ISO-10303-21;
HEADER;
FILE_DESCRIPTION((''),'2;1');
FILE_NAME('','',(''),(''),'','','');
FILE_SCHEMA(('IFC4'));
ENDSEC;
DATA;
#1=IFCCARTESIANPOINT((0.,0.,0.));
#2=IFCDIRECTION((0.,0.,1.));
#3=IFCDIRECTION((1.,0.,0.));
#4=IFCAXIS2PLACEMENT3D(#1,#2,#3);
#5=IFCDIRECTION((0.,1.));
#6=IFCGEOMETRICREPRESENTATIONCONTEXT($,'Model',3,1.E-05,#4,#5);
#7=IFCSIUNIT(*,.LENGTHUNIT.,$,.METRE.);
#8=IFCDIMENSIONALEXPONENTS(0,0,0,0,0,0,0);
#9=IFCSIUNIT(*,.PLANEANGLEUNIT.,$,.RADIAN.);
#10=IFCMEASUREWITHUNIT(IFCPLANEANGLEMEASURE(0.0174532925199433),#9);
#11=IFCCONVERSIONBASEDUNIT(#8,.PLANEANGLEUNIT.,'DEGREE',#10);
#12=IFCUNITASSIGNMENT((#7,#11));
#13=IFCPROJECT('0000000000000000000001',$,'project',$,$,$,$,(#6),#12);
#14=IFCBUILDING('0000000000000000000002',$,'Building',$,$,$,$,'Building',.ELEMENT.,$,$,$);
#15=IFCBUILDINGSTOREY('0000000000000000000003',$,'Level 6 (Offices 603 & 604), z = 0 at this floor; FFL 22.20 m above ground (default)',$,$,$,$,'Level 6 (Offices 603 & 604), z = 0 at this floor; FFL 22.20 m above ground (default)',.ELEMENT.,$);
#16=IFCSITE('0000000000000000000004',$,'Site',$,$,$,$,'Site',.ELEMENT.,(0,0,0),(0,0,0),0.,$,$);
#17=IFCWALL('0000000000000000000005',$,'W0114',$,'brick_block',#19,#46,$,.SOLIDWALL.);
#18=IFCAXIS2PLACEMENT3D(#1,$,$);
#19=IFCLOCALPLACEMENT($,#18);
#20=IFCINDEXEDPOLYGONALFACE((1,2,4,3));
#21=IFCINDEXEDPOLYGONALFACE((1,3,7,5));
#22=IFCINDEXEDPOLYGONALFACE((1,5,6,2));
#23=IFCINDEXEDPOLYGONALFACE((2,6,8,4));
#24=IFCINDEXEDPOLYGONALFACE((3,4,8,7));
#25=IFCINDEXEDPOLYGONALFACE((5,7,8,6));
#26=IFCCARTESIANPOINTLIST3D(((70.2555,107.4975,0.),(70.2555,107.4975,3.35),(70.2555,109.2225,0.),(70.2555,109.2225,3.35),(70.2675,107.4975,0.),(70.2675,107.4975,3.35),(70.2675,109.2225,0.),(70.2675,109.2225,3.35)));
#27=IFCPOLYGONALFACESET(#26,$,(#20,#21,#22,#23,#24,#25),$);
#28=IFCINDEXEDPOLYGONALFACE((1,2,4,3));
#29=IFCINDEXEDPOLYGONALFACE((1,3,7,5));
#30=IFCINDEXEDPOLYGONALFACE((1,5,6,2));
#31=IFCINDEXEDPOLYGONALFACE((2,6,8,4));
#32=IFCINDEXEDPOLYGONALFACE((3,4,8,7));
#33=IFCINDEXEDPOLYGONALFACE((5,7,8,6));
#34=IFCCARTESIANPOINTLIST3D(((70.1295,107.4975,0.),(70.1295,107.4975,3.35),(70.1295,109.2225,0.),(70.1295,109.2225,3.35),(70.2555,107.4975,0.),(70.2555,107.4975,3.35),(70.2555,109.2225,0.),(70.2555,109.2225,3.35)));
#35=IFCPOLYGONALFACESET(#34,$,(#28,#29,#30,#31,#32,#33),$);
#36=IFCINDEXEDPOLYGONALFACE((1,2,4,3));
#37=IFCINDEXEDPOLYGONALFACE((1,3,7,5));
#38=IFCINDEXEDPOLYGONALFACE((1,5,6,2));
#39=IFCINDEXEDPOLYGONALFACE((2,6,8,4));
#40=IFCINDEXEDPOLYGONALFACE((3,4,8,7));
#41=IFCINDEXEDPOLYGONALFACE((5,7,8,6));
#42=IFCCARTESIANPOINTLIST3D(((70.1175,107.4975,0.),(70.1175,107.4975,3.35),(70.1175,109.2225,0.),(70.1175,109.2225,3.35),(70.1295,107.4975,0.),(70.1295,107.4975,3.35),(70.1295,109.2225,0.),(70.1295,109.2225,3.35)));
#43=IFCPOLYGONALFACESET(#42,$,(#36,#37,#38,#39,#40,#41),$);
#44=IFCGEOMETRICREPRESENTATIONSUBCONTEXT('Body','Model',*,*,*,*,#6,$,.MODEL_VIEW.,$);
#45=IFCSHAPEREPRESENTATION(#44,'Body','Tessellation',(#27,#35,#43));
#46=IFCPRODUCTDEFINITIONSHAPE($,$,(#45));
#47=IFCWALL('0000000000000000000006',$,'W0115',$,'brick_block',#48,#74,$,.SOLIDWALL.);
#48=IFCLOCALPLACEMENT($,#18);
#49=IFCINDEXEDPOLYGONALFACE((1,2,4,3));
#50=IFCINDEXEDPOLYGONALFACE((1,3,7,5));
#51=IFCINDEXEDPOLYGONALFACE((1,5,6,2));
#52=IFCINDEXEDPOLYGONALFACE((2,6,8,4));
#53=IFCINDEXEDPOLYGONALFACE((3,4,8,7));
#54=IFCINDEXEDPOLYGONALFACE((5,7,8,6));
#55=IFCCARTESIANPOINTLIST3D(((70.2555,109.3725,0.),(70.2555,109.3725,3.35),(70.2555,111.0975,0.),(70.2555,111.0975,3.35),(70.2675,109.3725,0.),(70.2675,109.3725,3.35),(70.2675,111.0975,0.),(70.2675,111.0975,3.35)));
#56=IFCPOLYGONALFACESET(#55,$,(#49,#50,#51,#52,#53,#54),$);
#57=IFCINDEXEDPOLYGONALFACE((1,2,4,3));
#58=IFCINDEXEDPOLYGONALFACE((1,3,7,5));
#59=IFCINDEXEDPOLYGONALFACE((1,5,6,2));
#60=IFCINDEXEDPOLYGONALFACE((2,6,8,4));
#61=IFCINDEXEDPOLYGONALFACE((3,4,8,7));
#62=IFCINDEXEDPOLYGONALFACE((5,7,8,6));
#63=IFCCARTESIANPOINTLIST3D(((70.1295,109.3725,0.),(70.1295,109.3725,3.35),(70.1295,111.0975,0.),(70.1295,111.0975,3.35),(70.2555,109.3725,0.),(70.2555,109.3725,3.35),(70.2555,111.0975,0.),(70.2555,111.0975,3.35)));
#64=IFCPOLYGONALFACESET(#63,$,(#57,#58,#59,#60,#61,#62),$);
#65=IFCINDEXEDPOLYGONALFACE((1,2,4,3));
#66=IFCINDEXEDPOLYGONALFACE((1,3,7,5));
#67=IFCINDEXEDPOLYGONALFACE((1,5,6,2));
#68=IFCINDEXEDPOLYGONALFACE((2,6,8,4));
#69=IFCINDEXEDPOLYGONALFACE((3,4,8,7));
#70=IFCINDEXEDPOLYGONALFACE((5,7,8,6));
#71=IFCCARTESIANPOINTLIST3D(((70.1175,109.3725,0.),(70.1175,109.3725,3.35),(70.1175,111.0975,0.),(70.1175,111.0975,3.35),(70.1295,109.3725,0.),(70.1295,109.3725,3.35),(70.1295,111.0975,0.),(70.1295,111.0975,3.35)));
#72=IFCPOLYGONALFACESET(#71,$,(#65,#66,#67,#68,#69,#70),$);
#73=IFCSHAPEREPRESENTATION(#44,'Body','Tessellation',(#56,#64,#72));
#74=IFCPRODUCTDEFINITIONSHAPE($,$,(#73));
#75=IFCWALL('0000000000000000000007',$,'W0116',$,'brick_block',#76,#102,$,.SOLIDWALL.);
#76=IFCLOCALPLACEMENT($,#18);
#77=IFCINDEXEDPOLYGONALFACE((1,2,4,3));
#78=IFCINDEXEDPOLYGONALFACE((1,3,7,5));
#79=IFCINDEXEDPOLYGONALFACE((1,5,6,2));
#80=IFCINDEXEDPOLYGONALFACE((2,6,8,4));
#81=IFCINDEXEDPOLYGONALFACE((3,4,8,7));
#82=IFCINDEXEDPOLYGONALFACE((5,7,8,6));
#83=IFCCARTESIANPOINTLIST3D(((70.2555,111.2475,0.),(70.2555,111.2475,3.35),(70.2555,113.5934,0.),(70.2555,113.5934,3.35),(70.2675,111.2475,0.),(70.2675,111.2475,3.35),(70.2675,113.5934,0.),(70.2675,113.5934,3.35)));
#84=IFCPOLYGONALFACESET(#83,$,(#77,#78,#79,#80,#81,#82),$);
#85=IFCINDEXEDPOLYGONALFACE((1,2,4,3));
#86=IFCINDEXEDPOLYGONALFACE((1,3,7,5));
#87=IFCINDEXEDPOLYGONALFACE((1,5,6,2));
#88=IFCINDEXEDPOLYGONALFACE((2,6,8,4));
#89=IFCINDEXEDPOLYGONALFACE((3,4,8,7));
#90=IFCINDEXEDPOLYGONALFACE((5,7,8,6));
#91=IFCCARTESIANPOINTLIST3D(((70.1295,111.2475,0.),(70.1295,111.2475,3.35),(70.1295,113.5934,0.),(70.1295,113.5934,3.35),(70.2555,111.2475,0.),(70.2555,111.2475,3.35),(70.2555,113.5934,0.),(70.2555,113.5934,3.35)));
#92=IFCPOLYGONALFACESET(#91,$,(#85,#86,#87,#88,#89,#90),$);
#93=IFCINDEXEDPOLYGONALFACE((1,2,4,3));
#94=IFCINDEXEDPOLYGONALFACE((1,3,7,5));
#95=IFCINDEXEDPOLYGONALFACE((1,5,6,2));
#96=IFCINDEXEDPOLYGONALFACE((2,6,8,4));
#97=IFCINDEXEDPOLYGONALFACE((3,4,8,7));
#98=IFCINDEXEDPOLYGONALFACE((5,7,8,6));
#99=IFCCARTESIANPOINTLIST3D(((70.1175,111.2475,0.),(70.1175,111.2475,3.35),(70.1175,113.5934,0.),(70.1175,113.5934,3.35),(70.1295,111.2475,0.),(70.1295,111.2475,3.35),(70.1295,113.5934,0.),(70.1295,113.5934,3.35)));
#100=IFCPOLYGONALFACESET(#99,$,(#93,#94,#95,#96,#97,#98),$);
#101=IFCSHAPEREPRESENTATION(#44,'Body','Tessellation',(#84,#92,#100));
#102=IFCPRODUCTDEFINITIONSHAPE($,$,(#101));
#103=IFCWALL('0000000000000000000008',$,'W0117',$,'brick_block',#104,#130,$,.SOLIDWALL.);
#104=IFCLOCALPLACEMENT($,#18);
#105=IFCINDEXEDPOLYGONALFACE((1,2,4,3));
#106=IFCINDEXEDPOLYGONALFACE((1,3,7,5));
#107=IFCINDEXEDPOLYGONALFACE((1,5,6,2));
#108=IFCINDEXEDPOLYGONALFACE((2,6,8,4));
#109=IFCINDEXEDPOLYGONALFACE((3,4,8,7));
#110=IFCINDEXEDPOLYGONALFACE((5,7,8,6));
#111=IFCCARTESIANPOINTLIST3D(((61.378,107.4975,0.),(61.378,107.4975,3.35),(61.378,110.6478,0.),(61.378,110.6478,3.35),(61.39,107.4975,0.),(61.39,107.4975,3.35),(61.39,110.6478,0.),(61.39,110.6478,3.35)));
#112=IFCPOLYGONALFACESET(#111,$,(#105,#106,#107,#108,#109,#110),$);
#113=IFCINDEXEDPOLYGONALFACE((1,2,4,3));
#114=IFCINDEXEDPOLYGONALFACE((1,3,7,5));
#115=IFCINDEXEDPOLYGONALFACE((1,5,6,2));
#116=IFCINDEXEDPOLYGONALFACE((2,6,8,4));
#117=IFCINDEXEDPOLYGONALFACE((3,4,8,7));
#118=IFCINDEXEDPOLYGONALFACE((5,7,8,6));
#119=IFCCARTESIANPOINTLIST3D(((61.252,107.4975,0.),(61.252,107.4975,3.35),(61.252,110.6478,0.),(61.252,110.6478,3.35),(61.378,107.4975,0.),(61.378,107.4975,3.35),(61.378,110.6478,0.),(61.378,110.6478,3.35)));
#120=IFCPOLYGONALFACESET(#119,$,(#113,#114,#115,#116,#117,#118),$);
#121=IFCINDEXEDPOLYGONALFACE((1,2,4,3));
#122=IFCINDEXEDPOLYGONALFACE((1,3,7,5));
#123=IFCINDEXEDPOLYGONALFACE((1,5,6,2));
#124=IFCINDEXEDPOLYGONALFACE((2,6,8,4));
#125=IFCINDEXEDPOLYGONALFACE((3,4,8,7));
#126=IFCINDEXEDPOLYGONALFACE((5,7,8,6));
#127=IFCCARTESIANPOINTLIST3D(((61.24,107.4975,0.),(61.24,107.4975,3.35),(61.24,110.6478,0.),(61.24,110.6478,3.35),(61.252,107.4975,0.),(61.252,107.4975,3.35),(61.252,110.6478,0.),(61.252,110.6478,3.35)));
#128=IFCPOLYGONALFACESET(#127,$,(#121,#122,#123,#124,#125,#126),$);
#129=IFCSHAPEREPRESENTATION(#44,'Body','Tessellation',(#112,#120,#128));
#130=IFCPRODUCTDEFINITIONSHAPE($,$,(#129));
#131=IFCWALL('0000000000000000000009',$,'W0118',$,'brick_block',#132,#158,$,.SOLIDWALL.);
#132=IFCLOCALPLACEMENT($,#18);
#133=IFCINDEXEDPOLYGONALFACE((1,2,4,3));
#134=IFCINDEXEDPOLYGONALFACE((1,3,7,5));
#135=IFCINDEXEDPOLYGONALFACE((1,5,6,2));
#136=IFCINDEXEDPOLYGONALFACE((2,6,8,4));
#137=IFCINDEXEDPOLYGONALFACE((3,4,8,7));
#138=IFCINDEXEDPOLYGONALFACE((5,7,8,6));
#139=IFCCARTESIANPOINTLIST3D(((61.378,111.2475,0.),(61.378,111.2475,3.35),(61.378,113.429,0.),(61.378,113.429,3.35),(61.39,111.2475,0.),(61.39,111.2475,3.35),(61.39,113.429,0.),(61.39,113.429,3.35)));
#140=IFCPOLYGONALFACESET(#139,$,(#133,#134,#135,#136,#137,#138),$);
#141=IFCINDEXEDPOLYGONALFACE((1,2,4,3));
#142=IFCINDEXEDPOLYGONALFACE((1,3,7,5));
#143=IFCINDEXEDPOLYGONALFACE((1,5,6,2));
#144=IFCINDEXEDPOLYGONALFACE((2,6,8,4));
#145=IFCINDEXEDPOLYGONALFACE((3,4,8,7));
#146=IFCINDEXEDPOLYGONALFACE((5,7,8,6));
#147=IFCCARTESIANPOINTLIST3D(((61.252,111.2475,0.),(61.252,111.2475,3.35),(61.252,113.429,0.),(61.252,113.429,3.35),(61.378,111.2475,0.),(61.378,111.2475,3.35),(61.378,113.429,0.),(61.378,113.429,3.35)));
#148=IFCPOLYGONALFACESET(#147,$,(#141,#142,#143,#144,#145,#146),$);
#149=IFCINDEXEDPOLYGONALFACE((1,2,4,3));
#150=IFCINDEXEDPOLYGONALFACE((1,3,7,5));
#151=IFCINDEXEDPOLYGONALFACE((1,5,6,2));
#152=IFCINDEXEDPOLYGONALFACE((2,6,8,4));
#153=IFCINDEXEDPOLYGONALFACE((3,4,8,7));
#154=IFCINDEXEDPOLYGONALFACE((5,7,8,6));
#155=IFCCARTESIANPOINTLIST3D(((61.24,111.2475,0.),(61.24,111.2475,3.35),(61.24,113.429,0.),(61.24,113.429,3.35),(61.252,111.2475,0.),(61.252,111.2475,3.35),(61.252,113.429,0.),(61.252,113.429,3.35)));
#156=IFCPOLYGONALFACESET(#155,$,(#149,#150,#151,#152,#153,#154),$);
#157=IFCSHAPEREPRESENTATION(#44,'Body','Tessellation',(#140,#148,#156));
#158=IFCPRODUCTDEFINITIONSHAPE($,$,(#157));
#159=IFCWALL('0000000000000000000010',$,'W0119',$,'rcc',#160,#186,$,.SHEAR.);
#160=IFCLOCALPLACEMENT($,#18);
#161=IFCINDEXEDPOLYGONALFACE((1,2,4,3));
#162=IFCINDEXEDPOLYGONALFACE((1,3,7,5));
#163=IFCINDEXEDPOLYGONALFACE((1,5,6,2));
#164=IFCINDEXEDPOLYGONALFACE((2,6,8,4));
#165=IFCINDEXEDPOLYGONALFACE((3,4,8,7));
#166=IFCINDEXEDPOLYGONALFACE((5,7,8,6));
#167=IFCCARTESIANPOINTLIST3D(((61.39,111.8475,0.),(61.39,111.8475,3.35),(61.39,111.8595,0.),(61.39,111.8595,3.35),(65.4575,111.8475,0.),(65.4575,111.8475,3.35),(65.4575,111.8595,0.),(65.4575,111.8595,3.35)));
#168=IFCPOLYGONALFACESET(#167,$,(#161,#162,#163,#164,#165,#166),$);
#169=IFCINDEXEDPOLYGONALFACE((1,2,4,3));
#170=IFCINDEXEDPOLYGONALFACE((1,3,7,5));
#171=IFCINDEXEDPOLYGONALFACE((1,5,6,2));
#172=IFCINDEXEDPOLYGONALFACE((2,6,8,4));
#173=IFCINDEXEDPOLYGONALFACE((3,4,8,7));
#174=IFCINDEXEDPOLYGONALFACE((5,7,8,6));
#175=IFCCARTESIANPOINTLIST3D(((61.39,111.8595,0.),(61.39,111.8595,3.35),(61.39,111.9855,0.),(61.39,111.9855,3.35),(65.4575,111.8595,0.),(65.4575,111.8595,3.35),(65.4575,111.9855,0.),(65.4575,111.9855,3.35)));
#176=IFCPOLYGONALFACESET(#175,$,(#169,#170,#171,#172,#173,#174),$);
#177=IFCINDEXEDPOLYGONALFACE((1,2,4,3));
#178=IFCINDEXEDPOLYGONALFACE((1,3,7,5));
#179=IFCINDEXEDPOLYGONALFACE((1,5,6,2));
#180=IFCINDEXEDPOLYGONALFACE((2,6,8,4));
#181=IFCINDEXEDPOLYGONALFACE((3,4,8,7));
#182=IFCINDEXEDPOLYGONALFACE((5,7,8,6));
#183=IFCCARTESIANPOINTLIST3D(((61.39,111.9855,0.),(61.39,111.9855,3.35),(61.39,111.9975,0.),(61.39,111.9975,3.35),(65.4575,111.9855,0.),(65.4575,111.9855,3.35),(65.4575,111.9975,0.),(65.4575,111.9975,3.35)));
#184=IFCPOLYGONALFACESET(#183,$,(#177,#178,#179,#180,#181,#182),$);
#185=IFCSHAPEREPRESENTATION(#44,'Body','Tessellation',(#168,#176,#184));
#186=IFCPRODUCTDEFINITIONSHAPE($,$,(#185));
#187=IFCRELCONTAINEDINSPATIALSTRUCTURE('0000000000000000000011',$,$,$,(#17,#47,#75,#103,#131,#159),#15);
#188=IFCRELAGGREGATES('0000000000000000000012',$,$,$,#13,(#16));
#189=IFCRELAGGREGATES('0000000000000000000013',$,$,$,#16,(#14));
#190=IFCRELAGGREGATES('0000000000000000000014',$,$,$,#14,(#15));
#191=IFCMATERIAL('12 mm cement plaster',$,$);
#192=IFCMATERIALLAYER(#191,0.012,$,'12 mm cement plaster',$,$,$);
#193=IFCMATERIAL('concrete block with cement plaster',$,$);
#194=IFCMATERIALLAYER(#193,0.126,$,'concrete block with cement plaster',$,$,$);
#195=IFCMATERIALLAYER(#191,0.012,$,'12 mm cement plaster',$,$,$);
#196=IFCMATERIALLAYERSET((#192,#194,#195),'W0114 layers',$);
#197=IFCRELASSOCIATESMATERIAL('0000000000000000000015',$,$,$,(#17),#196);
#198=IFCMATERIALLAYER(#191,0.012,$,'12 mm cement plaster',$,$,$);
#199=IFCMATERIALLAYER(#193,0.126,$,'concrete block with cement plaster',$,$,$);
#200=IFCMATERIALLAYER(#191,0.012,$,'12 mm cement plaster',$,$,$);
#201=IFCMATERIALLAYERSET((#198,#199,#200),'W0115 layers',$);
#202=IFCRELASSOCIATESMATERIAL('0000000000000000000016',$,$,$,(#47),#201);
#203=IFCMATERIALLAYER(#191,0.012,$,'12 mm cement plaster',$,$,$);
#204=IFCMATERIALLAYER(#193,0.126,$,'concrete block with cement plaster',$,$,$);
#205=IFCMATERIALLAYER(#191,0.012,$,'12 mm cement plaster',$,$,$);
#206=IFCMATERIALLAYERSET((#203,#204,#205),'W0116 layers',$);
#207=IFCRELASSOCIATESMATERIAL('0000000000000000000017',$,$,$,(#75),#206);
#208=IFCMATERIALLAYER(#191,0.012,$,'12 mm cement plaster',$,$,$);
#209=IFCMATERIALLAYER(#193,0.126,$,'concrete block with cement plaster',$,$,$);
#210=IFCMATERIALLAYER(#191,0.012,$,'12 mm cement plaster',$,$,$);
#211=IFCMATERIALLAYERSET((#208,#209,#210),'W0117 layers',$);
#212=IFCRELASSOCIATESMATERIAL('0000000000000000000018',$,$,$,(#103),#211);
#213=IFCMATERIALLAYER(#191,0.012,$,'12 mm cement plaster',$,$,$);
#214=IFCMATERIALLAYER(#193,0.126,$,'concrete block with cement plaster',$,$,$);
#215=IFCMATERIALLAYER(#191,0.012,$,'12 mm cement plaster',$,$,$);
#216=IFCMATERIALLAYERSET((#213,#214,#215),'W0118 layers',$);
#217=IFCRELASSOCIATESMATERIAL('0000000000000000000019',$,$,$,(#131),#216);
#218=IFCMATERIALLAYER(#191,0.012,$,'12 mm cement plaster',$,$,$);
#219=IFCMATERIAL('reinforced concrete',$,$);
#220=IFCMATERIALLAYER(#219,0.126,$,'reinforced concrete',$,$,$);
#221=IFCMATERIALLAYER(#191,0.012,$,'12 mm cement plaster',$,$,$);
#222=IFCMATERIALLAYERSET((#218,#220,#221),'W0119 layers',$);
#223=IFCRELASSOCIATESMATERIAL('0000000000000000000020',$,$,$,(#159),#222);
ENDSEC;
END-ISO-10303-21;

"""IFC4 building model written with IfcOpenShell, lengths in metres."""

from ifc_helpers import new_model, entity, si_unit, converted_unit, direction, frame, frame_2d, origin_with_axes, place, context, subcontext, project, spatial, rectangle, extrude, material, layer, layer_set, layer_usage, element, save


model = new_model("IFC4")

# Units and contexts
model_context = context("Model", 3, precision=1e-05, world=origin_with_axes(), true_north=direction((0.0, 1.0)))
body_context = subcontext(model_context, "Body", "Model", "MODEL_VIEW")
ifc_project = project(units=[si_unit("LENGTHUNIT", "METRE"), converted_unit("PLANEANGLEUNIT", "DEGREE", entity("IfcPlaneAngleMeasure", 0.0174532925199433), si_unit("PLANEANGLEUNIT", "RADIAN"), dimensions=[0, 0, 0, 0, 0, 0, 0])], contexts=[model_context])

# Site, building, storey
site = spatial("IfcSite", under=ifc_project, Name="Site", LongName="Site", CompositionType="ELEMENT", RefLatitude=(0, 0, 0), RefLongitude=(0, 0, 0), RefElevation=0.0)
building = spatial("IfcBuilding", under=site, Name="Building", LongName="Building", CompositionType="ELEMENT")
storey = spatial("IfcBuildingStorey", under=building, Name="Level 6 (Offices 603 & 604), z = 0 at this floor; FFL 22.20 m above ground (default)", LongName="Level 6 (Offices 603 & 604), z = 0 at this floor; FFL 22.20 m above ground (default)", CompositionType="ELEMENT")

# Walls
ifc_material_1 = material(Name="12 mm cement plaster")
ifc_layer_1 = layer(ifc_material_1, 0.012, Name="12 mm cement plaster")
ifc_material_2 = material(Name="concrete block with cement plaster")
ifc_layer_2 = layer(ifc_material_2, 0.126, Name="concrete block with cement plaster")
ifc_layer_3 = layer(ifc_material_1, 0.012, Name="12 mm cement plaster")
ifc_layer_set_1 = layer_set([ifc_layer_1, ifc_layer_2, ifc_layer_3], Name="W0114 layers")
ifc_layer_usage_1 = layer_usage(ifc_layer_set_1, "AXIS2", "POSITIVE", -0.075)
placement = place(None, origin_with_axes())
element("IfcWall", 1, at=placement, inside=storey, material=ifc_layer_usage_1, Name="W0114", ObjectType="brick_block", PredefinedType="SOLIDWALL", context=body_context, shape_type="SweptSolid", body=[
    extrude(rectangle(XDim=1.725, YDim=0.012, at=frame_2d((0.0, 0.0), x_axis=(0.0, 1.0))), frame((70.2615, 108.36, 0.0), z_axis=(0.0, 0.0, 1.0), x_axis=(1.0, 0.0, 0.0)), (0.0, 0.0, 1.0), 3.35),
    extrude(rectangle(XDim=1.725, YDim=0.126, at=frame_2d((-0.069, 0.0), x_axis=(0.0, 1.0))), frame((70.2615, 108.36, 0.0), z_axis=(0.0, 0.0, 1.0), x_axis=(1.0, 0.0, 0.0)), (0.0, 0.0, 1.0), 3.35),
    extrude(rectangle(XDim=1.725, YDim=0.012, at=frame_2d((-0.138, 0.0), x_axis=(0.0, 1.0))), frame((70.2615, 108.36, 0.0), z_axis=(0.0, 0.0, 1.0), x_axis=(1.0, 0.0, 0.0)), (0.0, 0.0, 1.0), 3.35),
])
ifc_layer_4 = layer(ifc_material_1, 0.012, Name="12 mm cement plaster")
ifc_layer_5 = layer(ifc_material_2, 0.126, Name="concrete block with cement plaster")
ifc_layer_6 = layer(ifc_material_1, 0.012, Name="12 mm cement plaster")
ifc_layer_set_2 = layer_set([ifc_layer_4, ifc_layer_5, ifc_layer_6], Name="W0115 layers")
ifc_layer_usage_2 = layer_usage(ifc_layer_set_2, "AXIS2", "POSITIVE", -0.075)
element("IfcWall", 2, at=placement, inside=storey, material=ifc_layer_usage_2, Name="W0115", ObjectType="brick_block", PredefinedType="SOLIDWALL", context=body_context, shape_type="SweptSolid", body=[
    extrude(rectangle(XDim=1.725, YDim=0.012, at=frame_2d((0.0, 0.0), x_axis=(0.0, 1.0))), frame((70.2615, 110.235, 0.0), z_axis=(0.0, 0.0, 1.0), x_axis=(1.0, 0.0, 0.0)), (0.0, 0.0, 1.0), 3.35),
    extrude(rectangle(XDim=1.725, YDim=0.126, at=frame_2d((-0.069, 0.0), x_axis=(0.0, 1.0))), frame((70.2615, 110.235, 0.0), z_axis=(0.0, 0.0, 1.0), x_axis=(1.0, 0.0, 0.0)), (0.0, 0.0, 1.0), 3.35),
    extrude(rectangle(XDim=1.725, YDim=0.012, at=frame_2d((-0.138, 0.0), x_axis=(0.0, 1.0))), frame((70.2615, 110.235, 0.0), z_axis=(0.0, 0.0, 1.0), x_axis=(1.0, 0.0, 0.0)), (0.0, 0.0, 1.0), 3.35),
])
ifc_layer_7 = layer(ifc_material_1, 0.012, Name="12 mm cement plaster")
ifc_layer_8 = layer(ifc_material_2, 0.126, Name="concrete block with cement plaster")
ifc_layer_9 = layer(ifc_material_1, 0.012, Name="12 mm cement plaster")
ifc_layer_set_3 = layer_set([ifc_layer_7, ifc_layer_8, ifc_layer_9], Name="W0116 layers")
ifc_layer_usage_3 = layer_usage(ifc_layer_set_3, "AXIS2", "POSITIVE", -0.075)
element("IfcWall", 3, at=placement, inside=storey, material=ifc_layer_usage_3, Name="W0116", ObjectType="brick_block", PredefinedType="SOLIDWALL", context=body_context, shape_type="SweptSolid", body=[
    extrude(rectangle(XDim=2.3459, YDim=0.012, at=frame_2d((0.0, 0.0), x_axis=(0.0, 1.0))), frame((70.2615, 112.4205, 0.0), z_axis=(0.0, 0.0, 1.0), x_axis=(1.0, 0.0, 0.0)), (0.0, 0.0, 1.0), 3.35),
    extrude(rectangle(XDim=2.3459, YDim=0.126, at=frame_2d((-0.069, 0.0), x_axis=(0.0, 1.0))), frame((70.2615, 112.4205, 0.0), z_axis=(0.0, 0.0, 1.0), x_axis=(1.0, 0.0, 0.0)), (0.0, 0.0, 1.0), 3.35),
    extrude(rectangle(XDim=2.3459, YDim=0.012, at=frame_2d((-0.138, 0.0), x_axis=(0.0, 1.0))), frame((70.2615, 112.4205, 0.0), z_axis=(0.0, 0.0, 1.0), x_axis=(1.0, 0.0, 0.0)), (0.0, 0.0, 1.0), 3.35),
])
ifc_layer_10 = layer(ifc_material_1, 0.012, Name="12 mm cement plaster")
ifc_layer_11 = layer(ifc_material_2, 0.126, Name="concrete block with cement plaster")
ifc_layer_12 = layer(ifc_material_1, 0.012, Name="12 mm cement plaster")
ifc_layer_set_4 = layer_set([ifc_layer_10, ifc_layer_11, ifc_layer_12], Name="W0117 layers")
ifc_layer_usage_4 = layer_usage(ifc_layer_set_4, "AXIS2", "POSITIVE", -0.075)
element("IfcWall", 4, at=placement, inside=storey, material=ifc_layer_usage_4, Name="W0117", ObjectType="brick_block", PredefinedType="SOLIDWALL", context=body_context, shape_type="SweptSolid", body=[
    extrude(rectangle(XDim=3.1503, YDim=0.012, at=frame_2d((0.0, 0.0), x_axis=(0.0, 1.0))), frame((61.384, 109.0726, 0.0), z_axis=(0.0, 0.0, 1.0), x_axis=(1.0, 0.0, 0.0)), (0.0, 0.0, 1.0), 3.35),
    extrude(rectangle(XDim=3.1503, YDim=0.126, at=frame_2d((-0.069, 0.0), x_axis=(0.0, 1.0))), frame((61.384, 109.0726, 0.0), z_axis=(0.0, 0.0, 1.0), x_axis=(1.0, 0.0, 0.0)), (0.0, 0.0, 1.0), 3.35),
    extrude(rectangle(XDim=3.1503, YDim=0.012, at=frame_2d((-0.138, 0.0), x_axis=(0.0, 1.0))), frame((61.384, 109.0726, 0.0), z_axis=(0.0, 0.0, 1.0), x_axis=(1.0, 0.0, 0.0)), (0.0, 0.0, 1.0), 3.35),
])
ifc_layer_13 = layer(ifc_material_1, 0.012, Name="12 mm cement plaster")
ifc_layer_14 = layer(ifc_material_2, 0.126, Name="concrete block with cement plaster")
ifc_layer_15 = layer(ifc_material_1, 0.012, Name="12 mm cement plaster")
ifc_layer_set_5 = layer_set([ifc_layer_13, ifc_layer_14, ifc_layer_15], Name="W0118 layers")
ifc_layer_usage_5 = layer_usage(ifc_layer_set_5, "AXIS2", "POSITIVE", -0.075)
element("IfcWall", 5, at=placement, inside=storey, material=ifc_layer_usage_5, Name="W0118", ObjectType="brick_block", PredefinedType="SOLIDWALL", context=body_context, shape_type="SweptSolid", body=[
    extrude(rectangle(XDim=2.1815, YDim=0.012, at=frame_2d((0.0, 0.0), x_axis=(0.0, 1.0))), frame((61.384, 112.3383, 0.0), z_axis=(0.0, 0.0, 1.0), x_axis=(1.0, 0.0, 0.0)), (0.0, 0.0, 1.0), 3.35),
    extrude(rectangle(XDim=2.1815, YDim=0.126, at=frame_2d((-0.069, 0.0), x_axis=(0.0, 1.0))), frame((61.384, 112.3383, 0.0), z_axis=(0.0, 0.0, 1.0), x_axis=(1.0, 0.0, 0.0)), (0.0, 0.0, 1.0), 3.35),
    extrude(rectangle(XDim=2.1815, YDim=0.012, at=frame_2d((-0.138, 0.0), x_axis=(0.0, 1.0))), frame((61.384, 112.3383, 0.0), z_axis=(0.0, 0.0, 1.0), x_axis=(1.0, 0.0, 0.0)), (0.0, 0.0, 1.0), 3.35),
])
ifc_layer_16 = layer(ifc_material_1, 0.012, Name="12 mm cement plaster")
ifc_material_3 = material(Name="reinforced concrete")
ifc_layer_17 = layer(ifc_material_3, 0.126, Name="reinforced concrete")
ifc_layer_18 = layer(ifc_material_1, 0.012, Name="12 mm cement plaster")
ifc_layer_set_6 = layer_set([ifc_layer_16, ifc_layer_17, ifc_layer_18], Name="W0119 layers")
ifc_layer_usage_6 = layer_usage(ifc_layer_set_6, "AXIS2", "POSITIVE", -0.075)
element("IfcWall", 6, at=placement, inside=storey, material=ifc_layer_usage_6, Name="W0119", ObjectType="rcc", PredefinedType="SHEAR", context=body_context, shape_type="SweptSolid", body=[
    extrude(rectangle(XDim=4.0675, YDim=0.012, at=frame_2d((0.0, 0.0), x_axis=(1.0, 0.0))), frame((63.4237, 111.8535, 0.0), z_axis=(0.0, 0.0, 1.0), x_axis=(1.0, 0.0, 0.0)), (0.0, 0.0, 1.0), 3.35),
    extrude(rectangle(XDim=4.0675, YDim=0.126, at=frame_2d((0.0, 0.069), x_axis=(1.0, 0.0))), frame((63.4237, 111.8535, 0.0), z_axis=(0.0, 0.0, 1.0), x_axis=(1.0, 0.0, 0.0)), (0.0, 0.0, 1.0), 3.35),
    extrude(rectangle(XDim=4.0675, YDim=0.012, at=frame_2d((0.0, 0.138), x_axis=(1.0, 0.0))), frame((63.4237, 111.8535, 0.0), z_axis=(0.0, 0.0, 1.0), x_axis=(1.0, 0.0, 0.0)), (0.0, 0.0, 1.0), 3.35),
])

save(model, "model.ifc")
